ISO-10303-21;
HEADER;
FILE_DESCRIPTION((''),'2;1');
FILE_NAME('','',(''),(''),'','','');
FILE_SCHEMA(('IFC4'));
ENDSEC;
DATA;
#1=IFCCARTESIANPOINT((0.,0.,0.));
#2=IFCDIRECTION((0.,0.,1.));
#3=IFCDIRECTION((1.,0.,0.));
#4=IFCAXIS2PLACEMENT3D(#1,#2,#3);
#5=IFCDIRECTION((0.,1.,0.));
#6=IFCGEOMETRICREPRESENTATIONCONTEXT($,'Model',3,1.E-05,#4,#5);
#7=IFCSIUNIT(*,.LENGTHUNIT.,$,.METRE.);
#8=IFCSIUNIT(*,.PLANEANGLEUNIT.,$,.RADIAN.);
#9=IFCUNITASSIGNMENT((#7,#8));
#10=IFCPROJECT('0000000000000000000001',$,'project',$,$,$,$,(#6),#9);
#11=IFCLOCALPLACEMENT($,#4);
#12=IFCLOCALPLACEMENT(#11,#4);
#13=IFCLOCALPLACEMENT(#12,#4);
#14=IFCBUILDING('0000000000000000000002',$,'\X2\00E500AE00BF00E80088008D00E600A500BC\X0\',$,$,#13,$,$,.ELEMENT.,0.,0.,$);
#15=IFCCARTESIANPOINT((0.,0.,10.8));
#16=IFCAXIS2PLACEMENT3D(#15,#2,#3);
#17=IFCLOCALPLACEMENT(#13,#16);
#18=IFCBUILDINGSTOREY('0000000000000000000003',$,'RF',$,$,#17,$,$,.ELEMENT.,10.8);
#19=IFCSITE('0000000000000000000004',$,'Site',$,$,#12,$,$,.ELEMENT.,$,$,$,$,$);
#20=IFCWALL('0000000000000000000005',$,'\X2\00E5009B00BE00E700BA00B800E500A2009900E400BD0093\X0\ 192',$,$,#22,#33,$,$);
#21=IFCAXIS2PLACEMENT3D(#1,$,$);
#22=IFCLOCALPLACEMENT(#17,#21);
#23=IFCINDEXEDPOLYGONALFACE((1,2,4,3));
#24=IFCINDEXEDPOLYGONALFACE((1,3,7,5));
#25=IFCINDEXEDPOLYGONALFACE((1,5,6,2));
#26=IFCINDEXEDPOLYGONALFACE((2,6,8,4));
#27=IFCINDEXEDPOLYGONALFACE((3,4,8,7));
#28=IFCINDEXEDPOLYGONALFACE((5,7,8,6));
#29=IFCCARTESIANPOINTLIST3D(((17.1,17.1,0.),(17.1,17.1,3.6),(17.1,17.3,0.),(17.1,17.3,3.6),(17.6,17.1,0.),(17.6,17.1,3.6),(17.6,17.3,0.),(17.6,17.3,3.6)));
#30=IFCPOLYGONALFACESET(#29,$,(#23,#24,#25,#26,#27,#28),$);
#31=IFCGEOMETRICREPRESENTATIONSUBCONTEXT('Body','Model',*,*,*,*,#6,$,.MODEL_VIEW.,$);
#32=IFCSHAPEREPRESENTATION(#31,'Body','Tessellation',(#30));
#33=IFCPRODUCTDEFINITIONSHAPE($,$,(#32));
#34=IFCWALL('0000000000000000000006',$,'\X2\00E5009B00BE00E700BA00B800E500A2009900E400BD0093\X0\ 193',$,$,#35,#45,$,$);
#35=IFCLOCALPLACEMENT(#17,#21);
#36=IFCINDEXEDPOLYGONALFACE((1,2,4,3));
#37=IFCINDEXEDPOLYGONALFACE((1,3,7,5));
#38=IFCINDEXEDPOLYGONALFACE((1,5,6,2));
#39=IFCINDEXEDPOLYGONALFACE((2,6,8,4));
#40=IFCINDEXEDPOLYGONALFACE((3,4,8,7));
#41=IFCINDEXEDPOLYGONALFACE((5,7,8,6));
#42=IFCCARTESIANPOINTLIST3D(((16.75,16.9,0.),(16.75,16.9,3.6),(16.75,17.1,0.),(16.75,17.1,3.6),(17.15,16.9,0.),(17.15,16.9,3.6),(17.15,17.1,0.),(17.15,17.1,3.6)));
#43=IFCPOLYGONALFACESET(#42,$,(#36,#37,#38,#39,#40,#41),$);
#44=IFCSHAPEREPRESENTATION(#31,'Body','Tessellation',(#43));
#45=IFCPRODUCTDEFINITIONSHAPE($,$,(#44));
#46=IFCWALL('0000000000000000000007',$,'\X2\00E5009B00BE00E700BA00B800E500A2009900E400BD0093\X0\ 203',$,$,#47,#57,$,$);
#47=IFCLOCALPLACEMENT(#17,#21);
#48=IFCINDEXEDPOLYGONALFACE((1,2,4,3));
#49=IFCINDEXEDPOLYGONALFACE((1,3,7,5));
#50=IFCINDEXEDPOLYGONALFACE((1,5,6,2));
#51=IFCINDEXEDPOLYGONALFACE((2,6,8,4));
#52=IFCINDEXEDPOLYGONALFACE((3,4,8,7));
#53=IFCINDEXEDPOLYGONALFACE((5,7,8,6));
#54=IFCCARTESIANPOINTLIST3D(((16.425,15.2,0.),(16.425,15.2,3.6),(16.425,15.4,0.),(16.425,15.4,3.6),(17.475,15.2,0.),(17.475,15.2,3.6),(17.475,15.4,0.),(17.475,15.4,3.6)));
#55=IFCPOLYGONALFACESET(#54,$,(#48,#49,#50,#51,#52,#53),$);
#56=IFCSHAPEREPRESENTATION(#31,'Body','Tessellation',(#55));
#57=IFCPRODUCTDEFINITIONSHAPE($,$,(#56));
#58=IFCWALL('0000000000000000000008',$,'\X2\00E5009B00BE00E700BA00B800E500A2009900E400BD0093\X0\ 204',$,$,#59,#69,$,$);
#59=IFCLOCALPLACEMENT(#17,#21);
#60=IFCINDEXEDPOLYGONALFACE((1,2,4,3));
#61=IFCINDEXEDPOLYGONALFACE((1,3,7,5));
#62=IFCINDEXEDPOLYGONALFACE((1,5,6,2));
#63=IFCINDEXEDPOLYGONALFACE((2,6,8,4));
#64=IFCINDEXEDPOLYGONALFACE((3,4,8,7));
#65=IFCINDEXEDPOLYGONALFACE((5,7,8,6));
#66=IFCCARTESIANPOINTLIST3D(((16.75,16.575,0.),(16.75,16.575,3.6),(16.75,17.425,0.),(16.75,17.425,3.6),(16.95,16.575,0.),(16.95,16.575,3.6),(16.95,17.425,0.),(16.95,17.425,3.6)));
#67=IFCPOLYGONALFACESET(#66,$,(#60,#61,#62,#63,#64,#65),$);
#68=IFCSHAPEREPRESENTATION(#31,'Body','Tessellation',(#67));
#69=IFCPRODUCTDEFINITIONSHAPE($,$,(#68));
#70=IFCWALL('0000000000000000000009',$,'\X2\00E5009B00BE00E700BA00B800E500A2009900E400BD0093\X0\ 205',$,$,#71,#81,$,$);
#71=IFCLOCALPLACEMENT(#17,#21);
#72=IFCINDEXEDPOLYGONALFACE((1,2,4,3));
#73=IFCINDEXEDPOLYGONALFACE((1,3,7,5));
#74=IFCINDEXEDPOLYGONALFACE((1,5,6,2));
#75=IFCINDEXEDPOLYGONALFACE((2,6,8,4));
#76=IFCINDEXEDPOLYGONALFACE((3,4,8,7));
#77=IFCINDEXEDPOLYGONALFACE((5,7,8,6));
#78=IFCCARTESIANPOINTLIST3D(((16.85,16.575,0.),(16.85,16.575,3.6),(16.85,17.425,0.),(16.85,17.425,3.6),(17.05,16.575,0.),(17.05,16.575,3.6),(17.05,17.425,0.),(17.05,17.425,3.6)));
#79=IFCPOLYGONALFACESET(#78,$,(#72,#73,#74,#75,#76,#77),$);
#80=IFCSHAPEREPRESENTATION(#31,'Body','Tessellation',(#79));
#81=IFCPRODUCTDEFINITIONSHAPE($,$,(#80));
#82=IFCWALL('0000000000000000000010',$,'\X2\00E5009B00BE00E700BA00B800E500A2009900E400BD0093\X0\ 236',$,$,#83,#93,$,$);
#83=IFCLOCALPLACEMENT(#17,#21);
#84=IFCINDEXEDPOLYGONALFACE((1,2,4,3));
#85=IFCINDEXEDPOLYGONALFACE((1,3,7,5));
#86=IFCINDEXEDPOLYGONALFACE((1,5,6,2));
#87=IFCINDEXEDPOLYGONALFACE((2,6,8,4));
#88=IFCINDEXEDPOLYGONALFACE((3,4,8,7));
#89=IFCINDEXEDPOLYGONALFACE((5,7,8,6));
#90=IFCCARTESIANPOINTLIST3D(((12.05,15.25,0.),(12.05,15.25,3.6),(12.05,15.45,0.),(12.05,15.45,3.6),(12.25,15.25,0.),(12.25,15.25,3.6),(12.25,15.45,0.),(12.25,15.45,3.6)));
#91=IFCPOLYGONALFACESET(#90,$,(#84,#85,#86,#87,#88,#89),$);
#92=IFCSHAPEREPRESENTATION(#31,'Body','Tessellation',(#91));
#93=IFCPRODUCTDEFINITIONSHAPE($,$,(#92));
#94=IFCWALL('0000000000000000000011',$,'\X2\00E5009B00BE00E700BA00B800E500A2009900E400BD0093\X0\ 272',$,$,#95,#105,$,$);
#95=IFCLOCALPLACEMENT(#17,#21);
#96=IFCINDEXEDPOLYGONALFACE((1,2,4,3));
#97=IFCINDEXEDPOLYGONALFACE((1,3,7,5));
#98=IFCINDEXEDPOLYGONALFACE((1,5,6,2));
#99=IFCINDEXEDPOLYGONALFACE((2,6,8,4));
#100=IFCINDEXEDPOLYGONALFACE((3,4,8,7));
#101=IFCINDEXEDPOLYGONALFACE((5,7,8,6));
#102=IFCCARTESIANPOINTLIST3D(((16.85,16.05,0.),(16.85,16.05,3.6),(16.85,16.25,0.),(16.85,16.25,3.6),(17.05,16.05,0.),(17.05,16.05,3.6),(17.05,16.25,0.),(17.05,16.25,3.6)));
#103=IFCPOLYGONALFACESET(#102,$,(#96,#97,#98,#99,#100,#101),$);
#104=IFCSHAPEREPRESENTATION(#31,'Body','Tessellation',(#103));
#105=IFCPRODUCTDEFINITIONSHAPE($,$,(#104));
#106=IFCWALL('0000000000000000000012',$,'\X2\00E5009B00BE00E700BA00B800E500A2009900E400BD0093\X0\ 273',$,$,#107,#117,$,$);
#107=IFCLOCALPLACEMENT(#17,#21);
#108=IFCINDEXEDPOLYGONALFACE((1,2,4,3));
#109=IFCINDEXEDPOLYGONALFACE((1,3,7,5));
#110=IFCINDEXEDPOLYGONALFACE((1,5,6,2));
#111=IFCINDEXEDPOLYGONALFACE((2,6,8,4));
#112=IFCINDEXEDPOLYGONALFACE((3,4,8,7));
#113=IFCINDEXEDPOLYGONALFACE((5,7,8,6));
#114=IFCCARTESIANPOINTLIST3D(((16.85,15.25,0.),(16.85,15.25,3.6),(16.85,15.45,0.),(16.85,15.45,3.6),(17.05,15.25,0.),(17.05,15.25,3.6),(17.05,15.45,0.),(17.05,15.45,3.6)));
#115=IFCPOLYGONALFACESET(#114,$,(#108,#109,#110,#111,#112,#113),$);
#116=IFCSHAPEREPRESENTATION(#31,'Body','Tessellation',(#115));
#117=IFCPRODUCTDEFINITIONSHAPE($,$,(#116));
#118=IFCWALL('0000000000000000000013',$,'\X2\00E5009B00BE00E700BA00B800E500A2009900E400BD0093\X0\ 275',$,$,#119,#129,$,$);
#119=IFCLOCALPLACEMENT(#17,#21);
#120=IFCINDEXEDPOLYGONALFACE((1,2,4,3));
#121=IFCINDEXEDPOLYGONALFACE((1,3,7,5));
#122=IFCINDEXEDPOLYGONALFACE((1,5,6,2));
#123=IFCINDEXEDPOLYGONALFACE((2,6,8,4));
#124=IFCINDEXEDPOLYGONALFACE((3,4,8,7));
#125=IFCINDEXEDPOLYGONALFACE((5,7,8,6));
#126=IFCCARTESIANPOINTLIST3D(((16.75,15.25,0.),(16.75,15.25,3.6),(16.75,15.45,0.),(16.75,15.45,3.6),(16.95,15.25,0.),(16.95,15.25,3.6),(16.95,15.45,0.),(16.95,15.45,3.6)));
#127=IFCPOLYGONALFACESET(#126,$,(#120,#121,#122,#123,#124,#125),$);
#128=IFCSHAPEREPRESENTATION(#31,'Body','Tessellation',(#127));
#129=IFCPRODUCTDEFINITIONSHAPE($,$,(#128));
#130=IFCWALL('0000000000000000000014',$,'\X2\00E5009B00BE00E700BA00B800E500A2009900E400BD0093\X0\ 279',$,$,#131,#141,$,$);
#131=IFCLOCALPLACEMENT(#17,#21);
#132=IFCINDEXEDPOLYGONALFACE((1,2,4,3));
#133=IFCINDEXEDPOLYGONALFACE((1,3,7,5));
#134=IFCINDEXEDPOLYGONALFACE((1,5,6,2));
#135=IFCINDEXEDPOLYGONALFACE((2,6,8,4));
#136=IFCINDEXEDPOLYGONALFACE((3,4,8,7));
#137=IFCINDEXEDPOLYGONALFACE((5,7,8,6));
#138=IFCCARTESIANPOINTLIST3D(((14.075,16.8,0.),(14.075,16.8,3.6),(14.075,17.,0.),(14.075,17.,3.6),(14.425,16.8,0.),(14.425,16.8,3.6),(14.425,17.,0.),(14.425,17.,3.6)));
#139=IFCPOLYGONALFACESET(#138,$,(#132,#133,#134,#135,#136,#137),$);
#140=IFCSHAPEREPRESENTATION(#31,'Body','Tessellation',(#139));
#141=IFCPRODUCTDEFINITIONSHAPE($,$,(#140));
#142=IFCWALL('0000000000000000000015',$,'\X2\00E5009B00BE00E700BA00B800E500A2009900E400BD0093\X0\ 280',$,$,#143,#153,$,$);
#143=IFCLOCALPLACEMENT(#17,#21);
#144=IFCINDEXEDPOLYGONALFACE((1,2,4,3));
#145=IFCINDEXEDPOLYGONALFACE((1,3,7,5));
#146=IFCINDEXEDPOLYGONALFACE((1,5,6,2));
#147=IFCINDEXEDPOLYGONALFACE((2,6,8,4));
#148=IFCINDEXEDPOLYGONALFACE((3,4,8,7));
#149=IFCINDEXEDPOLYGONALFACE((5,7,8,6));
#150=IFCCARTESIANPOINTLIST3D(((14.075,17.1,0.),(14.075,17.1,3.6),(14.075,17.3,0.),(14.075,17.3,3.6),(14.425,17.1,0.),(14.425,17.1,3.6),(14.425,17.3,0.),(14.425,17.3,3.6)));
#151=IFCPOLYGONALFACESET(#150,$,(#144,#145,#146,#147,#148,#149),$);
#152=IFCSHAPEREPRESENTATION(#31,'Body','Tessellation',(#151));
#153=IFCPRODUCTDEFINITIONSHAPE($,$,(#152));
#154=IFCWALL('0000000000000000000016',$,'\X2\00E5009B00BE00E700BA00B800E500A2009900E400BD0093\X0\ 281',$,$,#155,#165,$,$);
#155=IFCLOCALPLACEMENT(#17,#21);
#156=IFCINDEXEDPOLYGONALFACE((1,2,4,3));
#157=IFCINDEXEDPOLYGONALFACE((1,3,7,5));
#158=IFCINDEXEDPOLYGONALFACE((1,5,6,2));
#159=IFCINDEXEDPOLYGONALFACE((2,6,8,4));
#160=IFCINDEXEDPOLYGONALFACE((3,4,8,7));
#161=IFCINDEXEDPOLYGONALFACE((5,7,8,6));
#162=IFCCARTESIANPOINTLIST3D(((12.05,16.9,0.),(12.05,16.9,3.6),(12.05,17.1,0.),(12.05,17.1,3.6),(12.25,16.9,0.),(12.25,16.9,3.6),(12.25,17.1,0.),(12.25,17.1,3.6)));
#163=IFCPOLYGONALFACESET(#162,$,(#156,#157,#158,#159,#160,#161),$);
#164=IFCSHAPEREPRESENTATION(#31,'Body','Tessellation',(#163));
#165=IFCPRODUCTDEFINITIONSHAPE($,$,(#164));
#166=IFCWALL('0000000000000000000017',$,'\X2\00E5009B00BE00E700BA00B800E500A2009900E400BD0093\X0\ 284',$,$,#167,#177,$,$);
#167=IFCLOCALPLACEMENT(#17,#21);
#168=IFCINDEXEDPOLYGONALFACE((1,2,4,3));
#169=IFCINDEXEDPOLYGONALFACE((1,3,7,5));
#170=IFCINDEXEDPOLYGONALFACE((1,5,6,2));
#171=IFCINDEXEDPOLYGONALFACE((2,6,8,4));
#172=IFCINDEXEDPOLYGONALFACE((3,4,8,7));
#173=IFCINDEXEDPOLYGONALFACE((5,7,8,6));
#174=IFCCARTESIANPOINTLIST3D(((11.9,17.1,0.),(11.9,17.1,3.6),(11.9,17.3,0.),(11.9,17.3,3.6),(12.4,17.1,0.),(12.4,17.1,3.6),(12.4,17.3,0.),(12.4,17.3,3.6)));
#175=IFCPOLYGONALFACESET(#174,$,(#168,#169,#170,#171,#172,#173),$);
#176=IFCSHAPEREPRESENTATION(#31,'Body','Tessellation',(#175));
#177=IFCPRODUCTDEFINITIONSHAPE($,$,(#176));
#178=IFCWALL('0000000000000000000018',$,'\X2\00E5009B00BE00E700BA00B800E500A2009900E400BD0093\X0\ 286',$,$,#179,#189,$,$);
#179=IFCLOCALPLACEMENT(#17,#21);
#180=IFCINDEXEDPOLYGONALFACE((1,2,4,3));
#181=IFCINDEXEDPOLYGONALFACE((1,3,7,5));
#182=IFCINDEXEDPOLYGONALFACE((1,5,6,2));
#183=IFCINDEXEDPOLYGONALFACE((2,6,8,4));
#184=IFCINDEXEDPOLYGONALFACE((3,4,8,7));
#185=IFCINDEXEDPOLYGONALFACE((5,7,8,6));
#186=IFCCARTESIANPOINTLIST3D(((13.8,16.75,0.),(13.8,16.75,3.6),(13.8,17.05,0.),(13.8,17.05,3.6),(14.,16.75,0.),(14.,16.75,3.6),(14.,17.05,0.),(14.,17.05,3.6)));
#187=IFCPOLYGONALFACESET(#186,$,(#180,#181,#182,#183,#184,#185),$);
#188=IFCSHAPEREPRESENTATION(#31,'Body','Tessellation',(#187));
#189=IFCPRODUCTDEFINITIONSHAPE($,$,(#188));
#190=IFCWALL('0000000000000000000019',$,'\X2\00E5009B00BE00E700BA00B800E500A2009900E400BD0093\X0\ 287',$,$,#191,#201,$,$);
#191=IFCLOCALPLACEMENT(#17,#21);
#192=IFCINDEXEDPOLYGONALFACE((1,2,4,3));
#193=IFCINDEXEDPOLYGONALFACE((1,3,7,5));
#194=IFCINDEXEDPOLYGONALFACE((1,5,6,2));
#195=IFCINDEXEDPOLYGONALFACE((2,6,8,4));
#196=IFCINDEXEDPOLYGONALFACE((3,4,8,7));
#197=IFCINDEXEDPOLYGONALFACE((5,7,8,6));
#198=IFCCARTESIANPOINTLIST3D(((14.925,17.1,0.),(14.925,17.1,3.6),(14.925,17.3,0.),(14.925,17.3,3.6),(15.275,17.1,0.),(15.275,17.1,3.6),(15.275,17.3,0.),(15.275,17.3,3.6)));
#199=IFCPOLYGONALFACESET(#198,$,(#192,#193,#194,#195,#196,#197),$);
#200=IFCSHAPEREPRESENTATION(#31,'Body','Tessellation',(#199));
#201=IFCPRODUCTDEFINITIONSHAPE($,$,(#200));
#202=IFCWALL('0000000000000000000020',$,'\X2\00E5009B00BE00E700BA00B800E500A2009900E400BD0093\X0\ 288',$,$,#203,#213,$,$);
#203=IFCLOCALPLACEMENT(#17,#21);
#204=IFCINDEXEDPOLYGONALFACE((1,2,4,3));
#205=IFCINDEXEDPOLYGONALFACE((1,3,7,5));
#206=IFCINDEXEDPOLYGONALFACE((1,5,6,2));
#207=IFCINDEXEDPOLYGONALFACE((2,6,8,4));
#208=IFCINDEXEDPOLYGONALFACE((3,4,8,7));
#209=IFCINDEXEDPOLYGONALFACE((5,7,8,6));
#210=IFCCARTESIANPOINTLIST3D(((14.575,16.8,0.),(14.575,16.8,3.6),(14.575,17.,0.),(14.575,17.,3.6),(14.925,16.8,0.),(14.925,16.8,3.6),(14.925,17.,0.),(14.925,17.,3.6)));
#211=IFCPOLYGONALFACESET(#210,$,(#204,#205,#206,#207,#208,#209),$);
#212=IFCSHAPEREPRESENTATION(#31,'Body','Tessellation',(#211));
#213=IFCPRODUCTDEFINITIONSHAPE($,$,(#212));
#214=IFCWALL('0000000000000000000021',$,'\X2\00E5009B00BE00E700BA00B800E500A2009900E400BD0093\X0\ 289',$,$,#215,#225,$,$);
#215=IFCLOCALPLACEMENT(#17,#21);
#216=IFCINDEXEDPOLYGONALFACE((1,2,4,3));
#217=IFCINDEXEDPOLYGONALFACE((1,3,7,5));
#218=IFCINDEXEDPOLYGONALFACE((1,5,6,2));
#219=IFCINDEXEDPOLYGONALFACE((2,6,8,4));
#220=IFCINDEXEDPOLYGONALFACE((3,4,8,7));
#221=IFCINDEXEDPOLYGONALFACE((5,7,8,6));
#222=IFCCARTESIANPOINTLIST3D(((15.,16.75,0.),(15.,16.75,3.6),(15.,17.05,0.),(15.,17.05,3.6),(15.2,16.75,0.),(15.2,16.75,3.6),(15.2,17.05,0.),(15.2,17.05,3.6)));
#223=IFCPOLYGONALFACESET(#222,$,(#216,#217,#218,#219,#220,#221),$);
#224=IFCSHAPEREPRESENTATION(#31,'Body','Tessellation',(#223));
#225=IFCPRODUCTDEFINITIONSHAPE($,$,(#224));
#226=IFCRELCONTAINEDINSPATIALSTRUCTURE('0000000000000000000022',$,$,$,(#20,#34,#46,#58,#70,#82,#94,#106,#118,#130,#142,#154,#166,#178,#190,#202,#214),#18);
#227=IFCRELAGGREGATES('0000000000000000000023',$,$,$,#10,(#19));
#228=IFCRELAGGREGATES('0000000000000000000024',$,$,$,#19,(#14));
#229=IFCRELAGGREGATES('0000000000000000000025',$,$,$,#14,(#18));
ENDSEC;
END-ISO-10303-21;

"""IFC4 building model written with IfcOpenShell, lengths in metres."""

from ifc_helpers import new_model, si_unit, direction, frame, frame_2d, origin_with_axes, place, context, subcontext, project, spatial, rectangle, extrude, element, save


model = new_model("IFC4")

# Units and contexts
model_context = context("Model", 3, precision=1e-05, world=origin_with_axes(), true_north=direction((0.0, 1.0, 0.0)))
body_context = subcontext(model_context, "Body", "Model", "MODEL_VIEW")
ifc_project = project(units=[si_unit("LENGTHUNIT", "METRE"), si_unit("PLANEANGLEUNIT", "RADIAN")], contexts=[model_context])

# Site, building, storey
placement = place(None, origin_with_axes())
site_placement = place(placement, origin_with_axes())
site = spatial("IfcSite", under=ifc_project, at=site_placement, Name="Site", CompositionType="ELEMENT")
building_placement = place(site_placement, origin_with_axes())
building = spatial("IfcBuilding", under=site, at=building_placement, Name="å®¿è\u0088\u008dæ¥¼", CompositionType="ELEMENT", ElevationOfRefHeight=0.0, ElevationOfTerrain=0.0)
storey_placement = place(building_placement, frame((0.0, 0.0, 10.8), z_axis=(0.0, 0.0, 1.0), x_axis=(1.0, 0.0, 0.0)))
storey = spatial("IfcBuildingStorey", under=building, at=storey_placement, Name="RF", CompositionType="ELEMENT", Elevation=10.8)

# Walls
wall_1_placement = place(storey_placement, frame((17.35, 17.2, 0.0), z_axis=(0.0, 0.0, 1.0), x_axis=(-1.0, 0.0, 0.0)))
element("IfcWall", 1, at=wall_1_placement, inside=storey, Name="å\u009b¾çº¸å¢\u0099ä½\u0093 192", context=body_context, shape_type="SweptSolid", body=[
    extrude(rectangle(XDim=0.5, YDim=0.2, at=frame_2d((0.0, 0.0), x_axis=(1.0, 0.0, 0.0))), frame((0.0, 0.0, 0.0), z_axis=(0.0, 0.0, 1.0)), (0.0, 0.0, 1.0), 3.6),
])
wall_2_placement = place(storey_placement, frame((16.95, 17.0, 0.0), z_axis=(0.0, 0.0, 1.0), x_axis=(1.0, 0.0, 0.0)))
element("IfcWall", 2, at=wall_2_placement, inside=storey, Name="å\u009b¾çº¸å¢\u0099ä½\u0093 193", context=body_context, shape_type="SweptSolid", body=[
    extrude(rectangle(XDim=0.4, YDim=0.2, at=frame_2d((0.0, 0.0), x_axis=(1.0, 0.0, 0.0))), frame((0.0, 0.0, 0.0), z_axis=(0.0, 0.0, 1.0)), (0.0, 0.0, 1.0), 3.6),
])
wall_3_placement = place(storey_placement, frame((16.95, 15.3, 0.0), z_axis=(0.0, 0.0, 1.0), x_axis=(1.0, 0.0, 0.0)))
element("IfcWall", 3, at=wall_3_placement, inside=storey, Name="å\u009b¾çº¸å¢\u0099ä½\u0093 203", context=body_context, shape_type="SweptSolid", body=[
    extrude(rectangle(XDim=1.05, YDim=0.2, at=frame_2d((0.0, 0.0), x_axis=(1.0, 0.0, 0.0))), frame((0.0, 0.0, 0.0), z_axis=(0.0, 0.0, 1.0)), (0.0, 0.0, 1.0), 3.6),
])
for number, where, z_axis, x_axis, name in (
    (4, (16.85, 17.0, 0.0), (0.0, 0.0, 1.0), (0.0, -1.0, 0.0), "å\u009b¾çº¸å¢\u0099ä½\u0093 204"),
    (5, (16.95, 17.0, 0.0), (0.0, 0.0, 1.0), (0.0, -1.0, 0.0), "å\u009b¾çº¸å¢\u0099ä½\u0093 205"),
):
    element("IfcWall", number, at=place(storey_placement, frame(where, z_axis=z_axis, x_axis=x_axis)), inside=storey, Name=name, context=body_context, shape_type="SweptSolid", body=[
        extrude(rectangle(XDim=0.85, YDim=0.2, at=frame_2d((0.0, 0.0), x_axis=(1.0, 0.0, 0.0))), frame((0.0, 0.0, 0.0), z_axis=(0.0, 0.0, 1.0)), (0.0, 0.0, 1.0), 3.6),
    ])
for number, where, z_axis, x_axis, name in (
    (6, (12.15, 15.35, 0.0), (0.0, 0.0, 1.0), (0.0, -1.0, 0.0), "å\u009b¾çº¸å¢\u0099ä½\u0093 236"),
    (7, (16.95, 16.15, 0.0), (0.0, 0.0, 1.0), (-1.0, 0.0, 0.0), "å\u009b¾çº¸å¢\u0099ä½\u0093 272"),
    (8, (16.95, 15.35, 0.0), (0.0, 0.0, 1.0), (-1.0, 0.0, 0.0), "å\u009b¾çº¸å¢\u0099ä½\u0093 273"),
    (9, (16.85, 15.35, 0.0), (0.0, 0.0, 1.0), (0.0, -1.0, 0.0), "å\u009b¾çº¸å¢\u0099ä½\u0093 275"),
):
    element("IfcWall", number, at=place(storey_placement, frame(where, z_axis=z_axis, x_axis=x_axis)), inside=storey, Name=name, context=body_context, shape_type="SweptSolid", body=[
        extrude(rectangle(XDim=0.2, YDim=0.2, at=frame_2d((0.0, 0.0), x_axis=(1.0, 0.0, 0.0))), frame((0.0, 0.0, 0.0), z_axis=(0.0, 0.0, 1.0)), (0.0, 0.0, 1.0), 3.6),
    ])
for number, where, z_axis, x_axis, name in (
    (10, (14.25, 16.9, 0.0), (0.0, 0.0, 1.0), (-1.0, 0.0, 0.0), "å\u009b¾çº¸å¢\u0099ä½\u0093 279"),
    (11, (14.25, 17.2, 0.0), (0.0, 0.0, 1.0), (-1.0, 0.0, 0.0), "å\u009b¾çº¸å¢\u0099ä½\u0093 280"),
):
    element("IfcWall", number, at=place(storey_placement, frame(where, z_axis=z_axis, x_axis=x_axis)), inside=storey, Name=name, context=body_context, shape_type="SweptSolid", body=[
        extrude(rectangle(XDim=0.35, YDim=0.2, at=frame_2d((0.0, 0.0), x_axis=(1.0, 0.0, 0.0))), frame((0.0, 0.0, 0.0), z_axis=(0.0, 0.0, 1.0)), (0.0, 0.0, 1.0), 3.6),
    ])
wall_4_placement = place(storey_placement, frame((12.15, 17.0, 0.0), z_axis=(0.0, 0.0, 1.0), x_axis=(0.0, 1.0, 0.0)))
element("IfcWall", 12, at=wall_4_placement, inside=storey, Name="å\u009b¾çº¸å¢\u0099ä½\u0093 281", context=body_context, shape_type="SweptSolid", body=[
    extrude(rectangle(XDim=0.2, YDim=0.2, at=frame_2d((0.0, 0.0), x_axis=(1.0, 0.0, 0.0))), frame((0.0, 0.0, 0.0), z_axis=(0.0, 0.0, 1.0)), (0.0, 0.0, 1.0), 3.6),
])
wall_5_placement = place(storey_placement, frame((12.15, 17.2, 0.0), z_axis=(0.0, 0.0, 1.0), x_axis=(-1.0, 0.0, 0.0)))
element("IfcWall", 13, at=wall_5_placement, inside=storey, Name="å\u009b¾çº¸å¢\u0099ä½\u0093 284", context=body_context, shape_type="SweptSolid", body=[
    extrude(rectangle(XDim=0.5, YDim=0.2, at=frame_2d((0.0, 0.0), x_axis=(1.0, 0.0, 0.0))), frame((0.0, 0.0, 0.0), z_axis=(0.0, 0.0, 1.0)), (0.0, 0.0, 1.0), 3.6),
])
wall_6_placement = place(storey_placement, frame((13.9, 16.9, 0.0), z_axis=(0.0, 0.0, 1.0), x_axis=(0.0, 1.0, 0.0)))
element("IfcWall", 14, at=wall_6_placement, inside=storey, Name="å\u009b¾çº¸å¢\u0099ä½\u0093 286", context=body_context, shape_type="SweptSolid", body=[
    extrude(rectangle(XDim=0.3, YDim=0.2, at=frame_2d((0.0, 0.0), x_axis=(1.0, 0.0, 0.0))), frame((0.0, 0.0, 0.0), z_axis=(0.0, 0.0, 1.0)), (0.0, 0.0, 1.0), 3.6),
])
for number, where, z_axis, x_axis, name in (
    (15, (15.1, 17.2, 0.0), (0.0, 0.0, 1.0), (-1.0, 0.0, 0.0), "å\u009b¾çº¸å¢\u0099ä½\u0093 287"),
    (16, (14.75, 16.9, 0.0), (0.0, 0.0, 1.0), (1.0, 0.0, 0.0), "å\u009b¾çº¸å¢\u0099ä½\u0093 288"),
):
    element("IfcWall", number, at=place(storey_placement, frame(where, z_axis=z_axis, x_axis=x_axis)), inside=storey, Name=name, context=body_context, shape_type="SweptSolid", body=[
        extrude(rectangle(XDim=0.35, YDim=0.2, at=frame_2d((0.0, 0.0), x_axis=(1.0, 0.0, 0.0))), frame((0.0, 0.0, 0.0), z_axis=(0.0, 0.0, 1.0)), (0.0, 0.0, 1.0), 3.6),
    ])
wall_7_placement = place(storey_placement, frame((15.1, 16.9, 0.0), z_axis=(0.0, 0.0, 1.0), x_axis=(0.0, 1.0, 0.0)))
element("IfcWall", 17, at=wall_7_placement, inside=storey, Name="å\u009b¾çº¸å¢\u0099ä½\u0093 289", context=body_context, shape_type="SweptSolid", body=[
    extrude(rectangle(XDim=0.3, YDim=0.2, at=frame_2d((0.0, 0.0), x_axis=(1.0, 0.0, 0.0))), frame((0.0, 0.0, 0.0), z_axis=(0.0, 0.0, 1.0)), (0.0, 0.0, 1.0), 3.6),
])

save(model, "model.ifc")
